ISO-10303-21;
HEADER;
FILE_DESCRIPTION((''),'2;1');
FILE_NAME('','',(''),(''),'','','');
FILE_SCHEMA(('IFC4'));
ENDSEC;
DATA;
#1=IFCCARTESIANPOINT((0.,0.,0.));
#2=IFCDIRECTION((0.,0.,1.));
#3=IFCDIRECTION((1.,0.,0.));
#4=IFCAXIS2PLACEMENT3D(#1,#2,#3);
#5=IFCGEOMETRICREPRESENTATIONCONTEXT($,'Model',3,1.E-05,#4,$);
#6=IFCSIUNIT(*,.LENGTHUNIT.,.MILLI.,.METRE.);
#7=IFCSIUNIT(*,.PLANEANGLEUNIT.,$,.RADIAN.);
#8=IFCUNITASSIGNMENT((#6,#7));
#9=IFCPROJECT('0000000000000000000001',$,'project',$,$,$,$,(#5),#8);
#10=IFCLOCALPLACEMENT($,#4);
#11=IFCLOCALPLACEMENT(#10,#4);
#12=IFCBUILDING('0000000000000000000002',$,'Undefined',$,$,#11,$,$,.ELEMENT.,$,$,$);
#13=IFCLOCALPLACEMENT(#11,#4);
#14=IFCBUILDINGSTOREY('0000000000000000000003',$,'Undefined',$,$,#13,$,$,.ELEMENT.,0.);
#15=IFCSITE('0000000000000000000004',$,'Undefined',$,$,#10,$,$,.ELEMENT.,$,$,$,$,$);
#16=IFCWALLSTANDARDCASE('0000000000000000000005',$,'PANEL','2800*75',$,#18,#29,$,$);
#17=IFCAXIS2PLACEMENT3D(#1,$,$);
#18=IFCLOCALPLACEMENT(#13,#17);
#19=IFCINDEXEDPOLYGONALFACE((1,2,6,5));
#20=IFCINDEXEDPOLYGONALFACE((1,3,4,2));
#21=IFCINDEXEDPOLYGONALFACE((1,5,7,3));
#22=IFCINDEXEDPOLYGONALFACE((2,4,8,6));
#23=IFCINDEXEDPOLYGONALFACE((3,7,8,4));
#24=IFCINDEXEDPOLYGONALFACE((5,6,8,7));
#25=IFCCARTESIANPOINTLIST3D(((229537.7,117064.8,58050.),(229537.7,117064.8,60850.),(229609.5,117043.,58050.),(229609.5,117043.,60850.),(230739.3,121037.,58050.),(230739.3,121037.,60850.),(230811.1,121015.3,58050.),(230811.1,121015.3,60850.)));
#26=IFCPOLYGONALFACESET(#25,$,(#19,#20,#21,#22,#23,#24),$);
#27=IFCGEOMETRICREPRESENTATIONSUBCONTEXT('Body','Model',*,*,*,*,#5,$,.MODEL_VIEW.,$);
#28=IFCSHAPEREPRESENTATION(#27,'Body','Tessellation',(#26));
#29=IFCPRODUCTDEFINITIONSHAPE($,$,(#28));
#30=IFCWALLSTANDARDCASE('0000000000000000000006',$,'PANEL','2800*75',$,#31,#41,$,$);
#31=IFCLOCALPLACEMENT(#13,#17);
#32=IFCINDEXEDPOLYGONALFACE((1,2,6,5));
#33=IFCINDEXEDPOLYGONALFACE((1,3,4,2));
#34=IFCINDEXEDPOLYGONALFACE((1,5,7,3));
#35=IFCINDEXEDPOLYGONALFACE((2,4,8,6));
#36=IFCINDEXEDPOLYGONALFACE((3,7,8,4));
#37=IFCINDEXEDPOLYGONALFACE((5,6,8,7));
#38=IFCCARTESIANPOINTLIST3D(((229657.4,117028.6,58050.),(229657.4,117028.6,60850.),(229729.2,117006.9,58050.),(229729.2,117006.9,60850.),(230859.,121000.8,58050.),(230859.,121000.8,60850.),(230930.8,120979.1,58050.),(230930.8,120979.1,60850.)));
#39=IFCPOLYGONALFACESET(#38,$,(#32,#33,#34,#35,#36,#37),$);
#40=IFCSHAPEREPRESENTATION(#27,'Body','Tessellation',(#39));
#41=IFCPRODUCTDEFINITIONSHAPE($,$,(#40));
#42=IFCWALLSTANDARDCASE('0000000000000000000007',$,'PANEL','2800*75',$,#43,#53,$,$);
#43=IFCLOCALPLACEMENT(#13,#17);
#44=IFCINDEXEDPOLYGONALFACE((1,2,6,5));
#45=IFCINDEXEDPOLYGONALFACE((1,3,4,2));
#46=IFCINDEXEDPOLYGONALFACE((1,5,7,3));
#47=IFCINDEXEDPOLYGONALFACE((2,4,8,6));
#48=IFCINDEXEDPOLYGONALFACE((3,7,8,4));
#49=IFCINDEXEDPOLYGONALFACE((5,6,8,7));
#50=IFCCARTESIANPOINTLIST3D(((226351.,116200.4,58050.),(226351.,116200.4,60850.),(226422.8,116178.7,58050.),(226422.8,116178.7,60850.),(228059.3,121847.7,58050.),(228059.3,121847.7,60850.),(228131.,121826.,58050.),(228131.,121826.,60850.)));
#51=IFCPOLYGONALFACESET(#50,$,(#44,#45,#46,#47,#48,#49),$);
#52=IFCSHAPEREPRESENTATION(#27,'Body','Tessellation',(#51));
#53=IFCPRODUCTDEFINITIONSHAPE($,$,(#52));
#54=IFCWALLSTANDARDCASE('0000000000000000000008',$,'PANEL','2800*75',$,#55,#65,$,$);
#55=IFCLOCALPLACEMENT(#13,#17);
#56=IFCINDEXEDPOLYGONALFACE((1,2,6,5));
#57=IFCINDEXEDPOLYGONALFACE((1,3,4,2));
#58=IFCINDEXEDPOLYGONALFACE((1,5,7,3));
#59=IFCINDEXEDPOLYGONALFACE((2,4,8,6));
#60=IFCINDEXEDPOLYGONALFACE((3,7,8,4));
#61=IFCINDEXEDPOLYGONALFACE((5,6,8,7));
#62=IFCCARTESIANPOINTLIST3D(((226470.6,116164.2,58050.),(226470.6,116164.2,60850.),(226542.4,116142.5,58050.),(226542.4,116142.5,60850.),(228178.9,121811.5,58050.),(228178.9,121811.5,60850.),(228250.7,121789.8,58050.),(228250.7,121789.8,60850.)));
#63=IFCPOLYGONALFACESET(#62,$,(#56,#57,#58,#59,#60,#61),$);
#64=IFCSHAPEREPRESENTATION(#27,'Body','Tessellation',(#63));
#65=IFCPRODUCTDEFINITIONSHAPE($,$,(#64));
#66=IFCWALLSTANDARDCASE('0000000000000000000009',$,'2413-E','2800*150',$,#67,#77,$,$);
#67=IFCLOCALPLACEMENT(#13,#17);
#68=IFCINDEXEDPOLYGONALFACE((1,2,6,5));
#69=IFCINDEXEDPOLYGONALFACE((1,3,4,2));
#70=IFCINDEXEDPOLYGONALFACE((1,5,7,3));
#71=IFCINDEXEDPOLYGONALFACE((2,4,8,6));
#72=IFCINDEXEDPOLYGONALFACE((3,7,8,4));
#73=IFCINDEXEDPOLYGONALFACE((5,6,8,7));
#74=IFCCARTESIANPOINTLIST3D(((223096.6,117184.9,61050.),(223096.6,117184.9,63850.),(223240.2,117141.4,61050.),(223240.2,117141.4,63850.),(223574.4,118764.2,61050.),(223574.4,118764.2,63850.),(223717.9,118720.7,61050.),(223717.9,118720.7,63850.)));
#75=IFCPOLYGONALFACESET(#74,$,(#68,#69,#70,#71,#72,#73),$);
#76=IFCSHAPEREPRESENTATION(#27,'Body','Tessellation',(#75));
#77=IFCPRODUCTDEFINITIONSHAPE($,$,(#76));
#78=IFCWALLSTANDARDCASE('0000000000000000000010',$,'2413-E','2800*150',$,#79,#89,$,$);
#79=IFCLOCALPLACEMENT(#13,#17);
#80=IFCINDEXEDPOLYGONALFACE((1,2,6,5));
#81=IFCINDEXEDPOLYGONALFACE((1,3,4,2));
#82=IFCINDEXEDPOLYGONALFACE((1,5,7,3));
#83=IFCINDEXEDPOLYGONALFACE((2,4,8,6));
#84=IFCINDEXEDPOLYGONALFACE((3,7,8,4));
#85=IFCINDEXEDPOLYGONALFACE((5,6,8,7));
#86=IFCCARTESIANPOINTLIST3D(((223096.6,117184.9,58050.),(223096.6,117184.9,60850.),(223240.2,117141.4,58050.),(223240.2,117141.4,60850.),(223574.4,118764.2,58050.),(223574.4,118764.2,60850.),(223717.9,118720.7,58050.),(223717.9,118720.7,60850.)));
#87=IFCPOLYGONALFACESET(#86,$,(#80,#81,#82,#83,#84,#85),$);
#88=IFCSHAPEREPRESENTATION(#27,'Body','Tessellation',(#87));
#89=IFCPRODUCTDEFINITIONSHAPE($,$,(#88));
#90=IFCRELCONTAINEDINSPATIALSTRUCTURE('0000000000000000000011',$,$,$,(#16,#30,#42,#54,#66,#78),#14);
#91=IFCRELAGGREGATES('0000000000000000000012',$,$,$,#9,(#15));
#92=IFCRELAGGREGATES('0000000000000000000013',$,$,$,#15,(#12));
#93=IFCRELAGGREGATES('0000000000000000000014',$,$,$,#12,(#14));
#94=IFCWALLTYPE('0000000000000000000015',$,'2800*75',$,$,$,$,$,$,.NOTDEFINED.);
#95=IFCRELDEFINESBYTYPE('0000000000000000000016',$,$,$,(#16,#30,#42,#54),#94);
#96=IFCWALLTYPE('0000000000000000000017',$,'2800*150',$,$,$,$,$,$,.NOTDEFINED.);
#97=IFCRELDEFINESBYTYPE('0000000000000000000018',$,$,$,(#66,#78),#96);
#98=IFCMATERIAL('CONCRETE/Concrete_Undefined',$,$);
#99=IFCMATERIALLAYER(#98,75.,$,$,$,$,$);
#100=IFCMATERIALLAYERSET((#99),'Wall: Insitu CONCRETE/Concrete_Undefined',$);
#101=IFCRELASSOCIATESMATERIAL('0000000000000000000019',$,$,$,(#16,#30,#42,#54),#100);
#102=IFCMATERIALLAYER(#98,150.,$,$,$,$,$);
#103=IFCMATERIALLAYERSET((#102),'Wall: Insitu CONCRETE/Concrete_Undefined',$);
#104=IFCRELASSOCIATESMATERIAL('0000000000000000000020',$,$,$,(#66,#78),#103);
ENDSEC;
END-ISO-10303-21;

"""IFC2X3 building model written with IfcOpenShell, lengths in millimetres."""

from ifc_helpers import new_model, si_unit, frame, frame_2d, origin_with_axes, place, context, subcontext, project, spatial, rectangle, extrude, material, layer, layer_set, layer_usage, type_object, element, save


model = new_model("IFC2X3")

# Units and contexts
model_context = context("Model", 3, precision=1e-05, world=origin_with_axes())
body_context = subcontext(model_context, "Body", "Model", "MODEL_VIEW")
ifc_project = project(units=[si_unit("LENGTHUNIT", "METRE", prefix="MILLI"), si_unit("PLANEANGLEUNIT", "RADIAN")], contexts=[model_context])

# Site, building, storey
site_placement = place(None, origin_with_axes())
site = spatial("IfcSite", under=ifc_project, at=site_placement, Name="Undefined", CompositionType="ELEMENT")
building_placement = place(site_placement, origin_with_axes())
building = spatial("IfcBuilding", under=site, at=building_placement, Name="Undefined", CompositionType="ELEMENT")
storey_placement = place(building_placement, origin_with_axes())
storey = spatial("IfcBuildingStorey", under=building, at=storey_placement, Name="Undefined", CompositionType="ELEMENT", Elevation=0.0)

# Walls
ifc_material_1 = material(Name="CONCRETE/Concrete_Undefined")
ifc_layer_1 = layer(ifc_material_1, 150.0)
ifc_layer_set_1 = layer_set([ifc_layer_1], Name="Wall: Insitu CONCRETE/Concrete_Undefined")
ifc_layer_2 = layer(ifc_material_1, 75.0)
ifc_layer_set_2 = layer_set([ifc_layer_2], Name="Wall: Insitu CONCRETE/Concrete_Undefined")
wall_type_1 = type_object("IfcWallType", Name="2800*75", PredefinedType="NOTDEFINED")
ifc_layer_usage_1 = layer_usage(ifc_layer_set_2, "AXIS2", "POSITIVE", -37.5)
wall_1_placement = place(storey_placement, frame((229573.6, 117053.9, 58050.0), z_axis=(0.0, 0.0, 1.0), x_axis=(0.289537, 0.957167, 0.0)))
element("IfcWallStandardCase", 1, at=wall_1_placement, inside=storey, type_object=wall_type_1, material=ifc_layer_usage_1, Name="PANEL", Description="2800*75", context=body_context, shape_type="SweptSolid", body=[
    extrude(rectangle(XDim=4150.0, YDim=75.0, at=frame_2d((0.0, 2075.0), x_axis=(0.0, -1.0))), frame((0.0, 0.0, 0.0), z_axis=(0.0, 0.0, 1.0), x_axis=(0.0, -1.0, 0.0)), (0.0, 0.0, 1.0), 2800.0),
])
ifc_layer_usage_2 = layer_usage(ifc_layer_set_2, "AXIS2", "POSITIVE", -37.5)
wall_2_placement = place(storey_placement, frame((229693.3, 117017.7, 58050.0), z_axis=(0.0, 0.0, 1.0), x_axis=(0.289537, 0.957167, 0.0)))
element("IfcWallStandardCase", 2, at=wall_2_placement, inside=storey, type_object=wall_type_1, material=ifc_layer_usage_2, Name="PANEL", Description="2800*75", context=body_context, shape_type="SweptSolid", body=[
    extrude(rectangle(XDim=4150.0, YDim=75.0, at=frame_2d((0.0, 2075.0), x_axis=(0.0, -1.0))), frame((0.0, 0.0, 0.0), z_axis=(0.0, 0.0, 1.0), x_axis=(0.0, -1.0, 0.0)), (0.0, 0.0, 1.0), 2800.0),
])
ifc_layer_usage_3 = layer_usage(ifc_layer_set_2, "AXIS2", "POSITIVE", -37.5)
wall_3_placement = place(storey_placement, frame((226386.9, 116189.6, 58050.0), z_axis=(0.0, 0.0, 1.0), x_axis=(0.289537, 0.957167, 0.0)))
element("IfcWallStandardCase", 3, at=wall_3_placement, inside=storey, type_object=wall_type_1, material=ifc_layer_usage_3, Name="PANEL", Description="2800*75", context=body_context, shape_type="SweptSolid", body=[
    extrude(rectangle(XDim=5900.0, YDim=75.0, at=frame_2d((0.0, 2950.0), x_axis=(0.0, -1.0))), frame((0.0, 0.0, 0.0), z_axis=(0.0, 0.0, 1.0), x_axis=(0.0, -1.0, 0.0)), (0.0, 0.0, 1.0), 2800.0),
])
ifc_layer_usage_4 = layer_usage(ifc_layer_set_2, "AXIS2", "POSITIVE", -37.5)
wall_4_placement = place(storey_placement, frame((226506.5, 116153.4, 58050.0), z_axis=(0.0, 0.0, 1.0), x_axis=(0.289537, 0.957167, 0.0)))
element("IfcWallStandardCase", 4, at=wall_4_placement, inside=storey, type_object=wall_type_1, material=ifc_layer_usage_4, Name="PANEL", Description="2800*75", context=body_context, shape_type="SweptSolid", body=[
    extrude(rectangle(XDim=5900.0, YDim=75.0, at=frame_2d((0.0, 2950.0), x_axis=(0.0, -1.0))), frame((0.0, 0.0, 0.0), z_axis=(0.0, 0.0, 1.0), x_axis=(0.0, -1.0, 0.0)), (0.0, 0.0, 1.0), 2800.0),
])
ifc_layer_usage_5 = layer_usage(ifc_layer_set_1, "AXIS2", "POSITIVE", -75.0)
wall_type_2 = type_object("IfcWallType", Name="2800*150", PredefinedType="NOTDEFINED")
wall_5_placement = place(storey_placement, frame((223646.1, 118742.5, 61050.0), z_axis=(0.0, 0.0, 1.0), x_axis=(-0.289535, -0.957167, 0.0)))
element("IfcWallStandardCase", 5, at=wall_5_placement, inside=storey, type_object=wall_type_2, material=ifc_layer_usage_5, Name="2413-E", Description="2800*150", context=body_context, shape_type="SweptSolid", body=[
    extrude(rectangle(XDim=1650.0, YDim=150.0, at=frame_2d((0.0, 825.0), x_axis=(0.0, -1.0))), frame((0.0, 0.0, 0.0), z_axis=(0.0, 0.0, 1.0), x_axis=(0.0, -1.0, 0.0)), (0.0, 0.0, 1.0), 2800.0),
])
ifc_layer_usage_6 = layer_usage(ifc_layer_set_1, "AXIS2", "POSITIVE", -75.0)
wall_6_placement = place(storey_placement, frame((223646.1, 118742.5, 58050.0), z_axis=(0.0, 0.0, 1.0), x_axis=(-0.289535, -0.957167, 0.0)))
element("IfcWallStandardCase", 6, at=wall_6_placement, inside=storey, type_object=wall_type_2, material=ifc_layer_usage_6, Name="2413-E", Description="2800*150", context=body_context, shape_type="SweptSolid", body=[
    extrude(rectangle(XDim=1650.0, YDim=150.0, at=frame_2d((0.0, 825.0), x_axis=(0.0, -1.0))), frame((0.0, 0.0, 0.0), z_axis=(0.0, 0.0, 1.0), x_axis=(0.0, -1.0, 0.0)), (0.0, 0.0, 1.0), 2800.0),
])

save(model, "model.ifc")
